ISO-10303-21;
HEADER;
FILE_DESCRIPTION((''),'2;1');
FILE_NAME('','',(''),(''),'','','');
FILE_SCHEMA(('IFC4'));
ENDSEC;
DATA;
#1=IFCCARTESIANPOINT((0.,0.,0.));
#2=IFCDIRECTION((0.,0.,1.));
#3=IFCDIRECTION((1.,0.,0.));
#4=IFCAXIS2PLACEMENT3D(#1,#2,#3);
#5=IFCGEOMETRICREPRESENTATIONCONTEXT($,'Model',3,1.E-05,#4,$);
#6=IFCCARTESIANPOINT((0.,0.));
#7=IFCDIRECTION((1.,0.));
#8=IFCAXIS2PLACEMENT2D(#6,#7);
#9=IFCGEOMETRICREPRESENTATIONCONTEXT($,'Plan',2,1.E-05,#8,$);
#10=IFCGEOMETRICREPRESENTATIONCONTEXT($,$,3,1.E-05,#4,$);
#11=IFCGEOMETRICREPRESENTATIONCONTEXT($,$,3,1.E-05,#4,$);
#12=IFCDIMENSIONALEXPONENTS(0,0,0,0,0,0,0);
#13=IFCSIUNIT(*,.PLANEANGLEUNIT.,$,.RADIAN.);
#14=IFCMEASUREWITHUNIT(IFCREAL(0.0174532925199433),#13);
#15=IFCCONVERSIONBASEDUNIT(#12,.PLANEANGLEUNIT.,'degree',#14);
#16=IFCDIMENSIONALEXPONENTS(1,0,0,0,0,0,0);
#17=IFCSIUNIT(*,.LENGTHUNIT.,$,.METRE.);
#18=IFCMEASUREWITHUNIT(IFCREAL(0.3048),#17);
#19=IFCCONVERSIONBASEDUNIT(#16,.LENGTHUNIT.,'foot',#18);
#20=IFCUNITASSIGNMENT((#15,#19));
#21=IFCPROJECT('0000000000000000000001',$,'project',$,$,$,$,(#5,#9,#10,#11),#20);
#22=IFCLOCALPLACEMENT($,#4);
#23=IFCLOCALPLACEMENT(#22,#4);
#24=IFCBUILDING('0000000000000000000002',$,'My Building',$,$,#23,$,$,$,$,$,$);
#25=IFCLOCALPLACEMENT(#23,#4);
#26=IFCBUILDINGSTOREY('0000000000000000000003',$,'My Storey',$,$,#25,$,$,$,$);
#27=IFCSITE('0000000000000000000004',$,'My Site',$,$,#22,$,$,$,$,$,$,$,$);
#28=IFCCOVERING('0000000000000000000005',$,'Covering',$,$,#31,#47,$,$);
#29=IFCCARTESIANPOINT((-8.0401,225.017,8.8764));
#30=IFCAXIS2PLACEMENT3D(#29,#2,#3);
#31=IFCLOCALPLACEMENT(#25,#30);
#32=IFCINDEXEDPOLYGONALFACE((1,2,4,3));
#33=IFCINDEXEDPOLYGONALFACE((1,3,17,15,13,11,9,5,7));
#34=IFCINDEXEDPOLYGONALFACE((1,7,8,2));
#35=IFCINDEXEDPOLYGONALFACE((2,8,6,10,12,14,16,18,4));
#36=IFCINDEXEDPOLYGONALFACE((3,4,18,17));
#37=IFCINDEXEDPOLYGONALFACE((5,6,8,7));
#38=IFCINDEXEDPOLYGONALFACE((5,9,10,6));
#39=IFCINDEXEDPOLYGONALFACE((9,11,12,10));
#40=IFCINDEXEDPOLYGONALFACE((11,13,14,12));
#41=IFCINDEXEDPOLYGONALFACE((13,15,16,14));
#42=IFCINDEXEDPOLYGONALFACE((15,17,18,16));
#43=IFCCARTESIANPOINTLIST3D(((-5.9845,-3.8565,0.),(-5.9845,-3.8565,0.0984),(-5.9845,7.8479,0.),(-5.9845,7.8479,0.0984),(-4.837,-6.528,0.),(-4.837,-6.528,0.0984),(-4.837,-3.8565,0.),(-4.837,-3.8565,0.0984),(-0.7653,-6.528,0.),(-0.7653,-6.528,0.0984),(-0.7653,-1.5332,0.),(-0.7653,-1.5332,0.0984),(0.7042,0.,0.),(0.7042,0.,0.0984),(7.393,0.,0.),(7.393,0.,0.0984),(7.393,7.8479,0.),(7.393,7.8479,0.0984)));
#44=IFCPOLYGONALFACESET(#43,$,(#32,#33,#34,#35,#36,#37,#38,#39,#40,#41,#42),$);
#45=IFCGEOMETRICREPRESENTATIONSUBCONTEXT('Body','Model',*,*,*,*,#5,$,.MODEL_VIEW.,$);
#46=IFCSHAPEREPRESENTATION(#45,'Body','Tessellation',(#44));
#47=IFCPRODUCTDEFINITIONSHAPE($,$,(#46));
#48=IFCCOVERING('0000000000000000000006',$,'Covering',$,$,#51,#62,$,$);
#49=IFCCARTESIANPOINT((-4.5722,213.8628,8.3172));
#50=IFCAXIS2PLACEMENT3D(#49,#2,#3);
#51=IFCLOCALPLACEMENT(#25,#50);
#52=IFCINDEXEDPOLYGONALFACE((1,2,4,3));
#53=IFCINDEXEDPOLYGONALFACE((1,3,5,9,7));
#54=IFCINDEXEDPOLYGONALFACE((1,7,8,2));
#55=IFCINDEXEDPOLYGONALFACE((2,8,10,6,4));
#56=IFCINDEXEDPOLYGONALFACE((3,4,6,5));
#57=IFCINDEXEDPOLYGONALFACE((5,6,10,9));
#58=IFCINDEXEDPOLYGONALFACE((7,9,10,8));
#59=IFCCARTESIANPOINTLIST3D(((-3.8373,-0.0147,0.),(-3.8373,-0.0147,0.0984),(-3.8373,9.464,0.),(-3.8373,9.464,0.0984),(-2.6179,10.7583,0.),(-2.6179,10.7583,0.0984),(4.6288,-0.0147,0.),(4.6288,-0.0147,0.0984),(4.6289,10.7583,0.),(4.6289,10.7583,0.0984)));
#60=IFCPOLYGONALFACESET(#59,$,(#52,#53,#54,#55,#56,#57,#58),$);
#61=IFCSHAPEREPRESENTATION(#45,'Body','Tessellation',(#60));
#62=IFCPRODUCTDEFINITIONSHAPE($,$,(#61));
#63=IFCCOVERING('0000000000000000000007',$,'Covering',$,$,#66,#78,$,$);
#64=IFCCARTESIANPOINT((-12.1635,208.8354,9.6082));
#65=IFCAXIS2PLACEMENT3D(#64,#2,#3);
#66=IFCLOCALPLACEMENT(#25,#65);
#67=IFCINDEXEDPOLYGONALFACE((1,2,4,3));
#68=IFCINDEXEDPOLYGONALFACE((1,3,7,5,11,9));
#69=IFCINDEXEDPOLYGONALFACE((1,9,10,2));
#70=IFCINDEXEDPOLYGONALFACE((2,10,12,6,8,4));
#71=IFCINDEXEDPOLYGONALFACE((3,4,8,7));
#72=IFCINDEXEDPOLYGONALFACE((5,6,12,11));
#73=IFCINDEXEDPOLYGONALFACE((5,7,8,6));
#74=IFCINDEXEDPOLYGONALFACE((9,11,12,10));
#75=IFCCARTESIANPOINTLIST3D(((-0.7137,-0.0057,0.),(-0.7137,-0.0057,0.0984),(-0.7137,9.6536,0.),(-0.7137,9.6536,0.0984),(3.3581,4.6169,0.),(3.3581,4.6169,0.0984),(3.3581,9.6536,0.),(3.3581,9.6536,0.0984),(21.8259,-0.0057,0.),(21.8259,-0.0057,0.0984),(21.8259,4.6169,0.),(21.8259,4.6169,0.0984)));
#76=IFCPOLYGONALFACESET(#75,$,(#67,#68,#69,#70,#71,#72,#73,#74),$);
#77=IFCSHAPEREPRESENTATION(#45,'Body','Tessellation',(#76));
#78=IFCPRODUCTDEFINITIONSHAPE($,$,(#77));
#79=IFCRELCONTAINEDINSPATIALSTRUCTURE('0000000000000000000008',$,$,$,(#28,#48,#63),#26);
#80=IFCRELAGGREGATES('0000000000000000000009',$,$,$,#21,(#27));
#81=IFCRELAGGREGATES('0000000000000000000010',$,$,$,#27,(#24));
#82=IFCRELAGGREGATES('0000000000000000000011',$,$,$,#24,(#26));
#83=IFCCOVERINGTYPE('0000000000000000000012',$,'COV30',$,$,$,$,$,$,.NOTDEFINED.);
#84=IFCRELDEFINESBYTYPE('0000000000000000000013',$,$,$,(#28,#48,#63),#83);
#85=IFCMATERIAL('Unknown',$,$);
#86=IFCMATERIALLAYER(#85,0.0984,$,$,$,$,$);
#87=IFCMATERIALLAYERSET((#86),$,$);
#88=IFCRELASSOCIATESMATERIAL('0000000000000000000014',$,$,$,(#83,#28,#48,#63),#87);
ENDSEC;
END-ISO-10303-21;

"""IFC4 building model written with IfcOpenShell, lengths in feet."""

from ifc_helpers import new_model, entity, si_unit, converted_unit, frame, origin_with_axes, origin_2d_with_axis, place, context, subcontext, project, spatial, line, indexed_curve, outline, extrude, material, layer, layer_set, layer_usage, type_object, element, save


model = new_model("IFC4")

# Units and contexts
model_context = context("Model", 3, precision=1e-05, world=origin_with_axes())
plan_context = context("Plan", 2, precision=1e-05, world=origin_2d_with_axis())
context_of_model_1 = context(None, 3, precision=1e-05, world=origin_with_axes())
context_of_model_2 = context(None, 3, precision=1e-05, world=origin_with_axes())
body_context_1 = subcontext(model_context, "Body", "Model", "MODEL_VIEW")
ifc_project = project(units=[converted_unit("PLANEANGLEUNIT", "degree", entity("IfcReal", 0.0174532925199433), si_unit("PLANEANGLEUNIT", "RADIAN"), dimensions=[0, 0, 0, 0, 0, 0, 0]), converted_unit("LENGTHUNIT", "foot", entity("IfcReal", 0.3048), si_unit("LENGTHUNIT", "METRE"), dimensions=[1, 0, 0, 0, 0, 0, 0])], contexts=[model_context, plan_context, context_of_model_1, context_of_model_2])

# Site, building, storey
site_placement = place(None, origin_with_axes())
site = spatial("IfcSite", under=ifc_project, at=site_placement, Name="My Site")
building_placement = place(site_placement, origin_with_axes())
building = spatial("IfcBuilding", under=site, at=building_placement, Name="My Building")
storey_placement = place(building_placement, origin_with_axes())
storey = spatial("IfcBuildingStorey", under=building, at=storey_placement, Name="My Storey")

# Coverings
ifc_material_1 = material(Name="Unknown")
ifc_layer_1 = layer(ifc_material_1, 0.0984)
ifc_layer_set_1 = layer_set([ifc_layer_1])
ifc_layer_usage_1 = layer_usage(ifc_layer_set_1, "AXIS3", "POSITIVE", 0.0)
covering_type = type_object("IfcCoveringType", Name="COV30", PredefinedType="NOTDEFINED", material=ifc_layer_set_1)
covering_1_placement = place(storey_placement, frame((-8.0401, 225.017, 8.8764), z_axis=(0.0, 0.0, 1.0), x_axis=(1.0, 0.0, 0.0)))
element("IfcCovering", 1, at=covering_1_placement, inside=storey, type_object=covering_type, material=ifc_layer_usage_1, Name="Covering", context=body_context_1, shape_type="SweptSolid", body=[
    extrude(outline(indexed_curve([(-5.9845, -3.8565), (-5.9845, 7.8479), (7.393, 7.8479), (7.393, 0.0), (0.7042, 0.0), (-0.7653, -1.5332), (-0.7653, -6.528), (-4.837, -6.528), (-4.837, -3.8565)], segments=[line(3, 2), line(2, 1), line(1, 9), line(9, 8), line(8, 7), line(7, 6), line(6, 5), line(5, 4), line(4, 3)], self_intersect=False)), None, (0.0, 0.0, 1.0), 0.0984),
])
ifc_layer_usage_2 = layer_usage(ifc_layer_set_1, "AXIS3", "POSITIVE", 0.0)
covering_2_placement = place(storey_placement, frame((-4.5722, 213.8628, 8.3172), z_axis=(0.0, 0.0, 1.0), x_axis=(1.0, 0.0, 0.0)))
element("IfcCovering", 2, at=covering_2_placement, inside=storey, type_object=covering_type, material=ifc_layer_usage_2, Name="Covering", context=body_context_1, shape_type="SweptSolid", body=[
    extrude(outline(indexed_curve([(-3.8373, 9.464), (-3.8373, -0.0147), (4.6288, -0.0147), (4.6289, 10.7583), (-2.6179, 10.7583)], segments=[line(4, 5), line(5, 1), line(1, 2), line(2, 3), line(3, 4)], self_intersect=False)), None, (0.0, 0.0, 1.0), 0.0984),
])
ifc_layer_usage_3 = layer_usage(ifc_layer_set_1, "AXIS3", "POSITIVE", 0.0)
covering_3_placement = place(storey_placement, frame((-12.1635, 208.8354, 9.6082), z_axis=(0.0, 0.0, 1.0), x_axis=(1.0, 0.0, 0.0)))
element("IfcCovering", 3, at=covering_3_placement, inside=storey, type_object=covering_type, material=ifc_layer_usage_3, Name="Covering", context=body_context_1, shape_type="SweptSolid", body=[
    extrude(outline(indexed_curve([(-0.7137, 9.6536), (3.3581, 9.6536), (21.8259, -0.0057), (-0.7137, -0.0057), (3.3581, 4.6169), (21.8259, 4.6169)], segments=[line(2, 5), line(5, 6), line(6, 3), line(3, 4), line(4, 1), line(1, 2)], self_intersect=False)), None, (0.0, 0.0, 1.0), 0.0984),
])

save(model, "model.ifc")
